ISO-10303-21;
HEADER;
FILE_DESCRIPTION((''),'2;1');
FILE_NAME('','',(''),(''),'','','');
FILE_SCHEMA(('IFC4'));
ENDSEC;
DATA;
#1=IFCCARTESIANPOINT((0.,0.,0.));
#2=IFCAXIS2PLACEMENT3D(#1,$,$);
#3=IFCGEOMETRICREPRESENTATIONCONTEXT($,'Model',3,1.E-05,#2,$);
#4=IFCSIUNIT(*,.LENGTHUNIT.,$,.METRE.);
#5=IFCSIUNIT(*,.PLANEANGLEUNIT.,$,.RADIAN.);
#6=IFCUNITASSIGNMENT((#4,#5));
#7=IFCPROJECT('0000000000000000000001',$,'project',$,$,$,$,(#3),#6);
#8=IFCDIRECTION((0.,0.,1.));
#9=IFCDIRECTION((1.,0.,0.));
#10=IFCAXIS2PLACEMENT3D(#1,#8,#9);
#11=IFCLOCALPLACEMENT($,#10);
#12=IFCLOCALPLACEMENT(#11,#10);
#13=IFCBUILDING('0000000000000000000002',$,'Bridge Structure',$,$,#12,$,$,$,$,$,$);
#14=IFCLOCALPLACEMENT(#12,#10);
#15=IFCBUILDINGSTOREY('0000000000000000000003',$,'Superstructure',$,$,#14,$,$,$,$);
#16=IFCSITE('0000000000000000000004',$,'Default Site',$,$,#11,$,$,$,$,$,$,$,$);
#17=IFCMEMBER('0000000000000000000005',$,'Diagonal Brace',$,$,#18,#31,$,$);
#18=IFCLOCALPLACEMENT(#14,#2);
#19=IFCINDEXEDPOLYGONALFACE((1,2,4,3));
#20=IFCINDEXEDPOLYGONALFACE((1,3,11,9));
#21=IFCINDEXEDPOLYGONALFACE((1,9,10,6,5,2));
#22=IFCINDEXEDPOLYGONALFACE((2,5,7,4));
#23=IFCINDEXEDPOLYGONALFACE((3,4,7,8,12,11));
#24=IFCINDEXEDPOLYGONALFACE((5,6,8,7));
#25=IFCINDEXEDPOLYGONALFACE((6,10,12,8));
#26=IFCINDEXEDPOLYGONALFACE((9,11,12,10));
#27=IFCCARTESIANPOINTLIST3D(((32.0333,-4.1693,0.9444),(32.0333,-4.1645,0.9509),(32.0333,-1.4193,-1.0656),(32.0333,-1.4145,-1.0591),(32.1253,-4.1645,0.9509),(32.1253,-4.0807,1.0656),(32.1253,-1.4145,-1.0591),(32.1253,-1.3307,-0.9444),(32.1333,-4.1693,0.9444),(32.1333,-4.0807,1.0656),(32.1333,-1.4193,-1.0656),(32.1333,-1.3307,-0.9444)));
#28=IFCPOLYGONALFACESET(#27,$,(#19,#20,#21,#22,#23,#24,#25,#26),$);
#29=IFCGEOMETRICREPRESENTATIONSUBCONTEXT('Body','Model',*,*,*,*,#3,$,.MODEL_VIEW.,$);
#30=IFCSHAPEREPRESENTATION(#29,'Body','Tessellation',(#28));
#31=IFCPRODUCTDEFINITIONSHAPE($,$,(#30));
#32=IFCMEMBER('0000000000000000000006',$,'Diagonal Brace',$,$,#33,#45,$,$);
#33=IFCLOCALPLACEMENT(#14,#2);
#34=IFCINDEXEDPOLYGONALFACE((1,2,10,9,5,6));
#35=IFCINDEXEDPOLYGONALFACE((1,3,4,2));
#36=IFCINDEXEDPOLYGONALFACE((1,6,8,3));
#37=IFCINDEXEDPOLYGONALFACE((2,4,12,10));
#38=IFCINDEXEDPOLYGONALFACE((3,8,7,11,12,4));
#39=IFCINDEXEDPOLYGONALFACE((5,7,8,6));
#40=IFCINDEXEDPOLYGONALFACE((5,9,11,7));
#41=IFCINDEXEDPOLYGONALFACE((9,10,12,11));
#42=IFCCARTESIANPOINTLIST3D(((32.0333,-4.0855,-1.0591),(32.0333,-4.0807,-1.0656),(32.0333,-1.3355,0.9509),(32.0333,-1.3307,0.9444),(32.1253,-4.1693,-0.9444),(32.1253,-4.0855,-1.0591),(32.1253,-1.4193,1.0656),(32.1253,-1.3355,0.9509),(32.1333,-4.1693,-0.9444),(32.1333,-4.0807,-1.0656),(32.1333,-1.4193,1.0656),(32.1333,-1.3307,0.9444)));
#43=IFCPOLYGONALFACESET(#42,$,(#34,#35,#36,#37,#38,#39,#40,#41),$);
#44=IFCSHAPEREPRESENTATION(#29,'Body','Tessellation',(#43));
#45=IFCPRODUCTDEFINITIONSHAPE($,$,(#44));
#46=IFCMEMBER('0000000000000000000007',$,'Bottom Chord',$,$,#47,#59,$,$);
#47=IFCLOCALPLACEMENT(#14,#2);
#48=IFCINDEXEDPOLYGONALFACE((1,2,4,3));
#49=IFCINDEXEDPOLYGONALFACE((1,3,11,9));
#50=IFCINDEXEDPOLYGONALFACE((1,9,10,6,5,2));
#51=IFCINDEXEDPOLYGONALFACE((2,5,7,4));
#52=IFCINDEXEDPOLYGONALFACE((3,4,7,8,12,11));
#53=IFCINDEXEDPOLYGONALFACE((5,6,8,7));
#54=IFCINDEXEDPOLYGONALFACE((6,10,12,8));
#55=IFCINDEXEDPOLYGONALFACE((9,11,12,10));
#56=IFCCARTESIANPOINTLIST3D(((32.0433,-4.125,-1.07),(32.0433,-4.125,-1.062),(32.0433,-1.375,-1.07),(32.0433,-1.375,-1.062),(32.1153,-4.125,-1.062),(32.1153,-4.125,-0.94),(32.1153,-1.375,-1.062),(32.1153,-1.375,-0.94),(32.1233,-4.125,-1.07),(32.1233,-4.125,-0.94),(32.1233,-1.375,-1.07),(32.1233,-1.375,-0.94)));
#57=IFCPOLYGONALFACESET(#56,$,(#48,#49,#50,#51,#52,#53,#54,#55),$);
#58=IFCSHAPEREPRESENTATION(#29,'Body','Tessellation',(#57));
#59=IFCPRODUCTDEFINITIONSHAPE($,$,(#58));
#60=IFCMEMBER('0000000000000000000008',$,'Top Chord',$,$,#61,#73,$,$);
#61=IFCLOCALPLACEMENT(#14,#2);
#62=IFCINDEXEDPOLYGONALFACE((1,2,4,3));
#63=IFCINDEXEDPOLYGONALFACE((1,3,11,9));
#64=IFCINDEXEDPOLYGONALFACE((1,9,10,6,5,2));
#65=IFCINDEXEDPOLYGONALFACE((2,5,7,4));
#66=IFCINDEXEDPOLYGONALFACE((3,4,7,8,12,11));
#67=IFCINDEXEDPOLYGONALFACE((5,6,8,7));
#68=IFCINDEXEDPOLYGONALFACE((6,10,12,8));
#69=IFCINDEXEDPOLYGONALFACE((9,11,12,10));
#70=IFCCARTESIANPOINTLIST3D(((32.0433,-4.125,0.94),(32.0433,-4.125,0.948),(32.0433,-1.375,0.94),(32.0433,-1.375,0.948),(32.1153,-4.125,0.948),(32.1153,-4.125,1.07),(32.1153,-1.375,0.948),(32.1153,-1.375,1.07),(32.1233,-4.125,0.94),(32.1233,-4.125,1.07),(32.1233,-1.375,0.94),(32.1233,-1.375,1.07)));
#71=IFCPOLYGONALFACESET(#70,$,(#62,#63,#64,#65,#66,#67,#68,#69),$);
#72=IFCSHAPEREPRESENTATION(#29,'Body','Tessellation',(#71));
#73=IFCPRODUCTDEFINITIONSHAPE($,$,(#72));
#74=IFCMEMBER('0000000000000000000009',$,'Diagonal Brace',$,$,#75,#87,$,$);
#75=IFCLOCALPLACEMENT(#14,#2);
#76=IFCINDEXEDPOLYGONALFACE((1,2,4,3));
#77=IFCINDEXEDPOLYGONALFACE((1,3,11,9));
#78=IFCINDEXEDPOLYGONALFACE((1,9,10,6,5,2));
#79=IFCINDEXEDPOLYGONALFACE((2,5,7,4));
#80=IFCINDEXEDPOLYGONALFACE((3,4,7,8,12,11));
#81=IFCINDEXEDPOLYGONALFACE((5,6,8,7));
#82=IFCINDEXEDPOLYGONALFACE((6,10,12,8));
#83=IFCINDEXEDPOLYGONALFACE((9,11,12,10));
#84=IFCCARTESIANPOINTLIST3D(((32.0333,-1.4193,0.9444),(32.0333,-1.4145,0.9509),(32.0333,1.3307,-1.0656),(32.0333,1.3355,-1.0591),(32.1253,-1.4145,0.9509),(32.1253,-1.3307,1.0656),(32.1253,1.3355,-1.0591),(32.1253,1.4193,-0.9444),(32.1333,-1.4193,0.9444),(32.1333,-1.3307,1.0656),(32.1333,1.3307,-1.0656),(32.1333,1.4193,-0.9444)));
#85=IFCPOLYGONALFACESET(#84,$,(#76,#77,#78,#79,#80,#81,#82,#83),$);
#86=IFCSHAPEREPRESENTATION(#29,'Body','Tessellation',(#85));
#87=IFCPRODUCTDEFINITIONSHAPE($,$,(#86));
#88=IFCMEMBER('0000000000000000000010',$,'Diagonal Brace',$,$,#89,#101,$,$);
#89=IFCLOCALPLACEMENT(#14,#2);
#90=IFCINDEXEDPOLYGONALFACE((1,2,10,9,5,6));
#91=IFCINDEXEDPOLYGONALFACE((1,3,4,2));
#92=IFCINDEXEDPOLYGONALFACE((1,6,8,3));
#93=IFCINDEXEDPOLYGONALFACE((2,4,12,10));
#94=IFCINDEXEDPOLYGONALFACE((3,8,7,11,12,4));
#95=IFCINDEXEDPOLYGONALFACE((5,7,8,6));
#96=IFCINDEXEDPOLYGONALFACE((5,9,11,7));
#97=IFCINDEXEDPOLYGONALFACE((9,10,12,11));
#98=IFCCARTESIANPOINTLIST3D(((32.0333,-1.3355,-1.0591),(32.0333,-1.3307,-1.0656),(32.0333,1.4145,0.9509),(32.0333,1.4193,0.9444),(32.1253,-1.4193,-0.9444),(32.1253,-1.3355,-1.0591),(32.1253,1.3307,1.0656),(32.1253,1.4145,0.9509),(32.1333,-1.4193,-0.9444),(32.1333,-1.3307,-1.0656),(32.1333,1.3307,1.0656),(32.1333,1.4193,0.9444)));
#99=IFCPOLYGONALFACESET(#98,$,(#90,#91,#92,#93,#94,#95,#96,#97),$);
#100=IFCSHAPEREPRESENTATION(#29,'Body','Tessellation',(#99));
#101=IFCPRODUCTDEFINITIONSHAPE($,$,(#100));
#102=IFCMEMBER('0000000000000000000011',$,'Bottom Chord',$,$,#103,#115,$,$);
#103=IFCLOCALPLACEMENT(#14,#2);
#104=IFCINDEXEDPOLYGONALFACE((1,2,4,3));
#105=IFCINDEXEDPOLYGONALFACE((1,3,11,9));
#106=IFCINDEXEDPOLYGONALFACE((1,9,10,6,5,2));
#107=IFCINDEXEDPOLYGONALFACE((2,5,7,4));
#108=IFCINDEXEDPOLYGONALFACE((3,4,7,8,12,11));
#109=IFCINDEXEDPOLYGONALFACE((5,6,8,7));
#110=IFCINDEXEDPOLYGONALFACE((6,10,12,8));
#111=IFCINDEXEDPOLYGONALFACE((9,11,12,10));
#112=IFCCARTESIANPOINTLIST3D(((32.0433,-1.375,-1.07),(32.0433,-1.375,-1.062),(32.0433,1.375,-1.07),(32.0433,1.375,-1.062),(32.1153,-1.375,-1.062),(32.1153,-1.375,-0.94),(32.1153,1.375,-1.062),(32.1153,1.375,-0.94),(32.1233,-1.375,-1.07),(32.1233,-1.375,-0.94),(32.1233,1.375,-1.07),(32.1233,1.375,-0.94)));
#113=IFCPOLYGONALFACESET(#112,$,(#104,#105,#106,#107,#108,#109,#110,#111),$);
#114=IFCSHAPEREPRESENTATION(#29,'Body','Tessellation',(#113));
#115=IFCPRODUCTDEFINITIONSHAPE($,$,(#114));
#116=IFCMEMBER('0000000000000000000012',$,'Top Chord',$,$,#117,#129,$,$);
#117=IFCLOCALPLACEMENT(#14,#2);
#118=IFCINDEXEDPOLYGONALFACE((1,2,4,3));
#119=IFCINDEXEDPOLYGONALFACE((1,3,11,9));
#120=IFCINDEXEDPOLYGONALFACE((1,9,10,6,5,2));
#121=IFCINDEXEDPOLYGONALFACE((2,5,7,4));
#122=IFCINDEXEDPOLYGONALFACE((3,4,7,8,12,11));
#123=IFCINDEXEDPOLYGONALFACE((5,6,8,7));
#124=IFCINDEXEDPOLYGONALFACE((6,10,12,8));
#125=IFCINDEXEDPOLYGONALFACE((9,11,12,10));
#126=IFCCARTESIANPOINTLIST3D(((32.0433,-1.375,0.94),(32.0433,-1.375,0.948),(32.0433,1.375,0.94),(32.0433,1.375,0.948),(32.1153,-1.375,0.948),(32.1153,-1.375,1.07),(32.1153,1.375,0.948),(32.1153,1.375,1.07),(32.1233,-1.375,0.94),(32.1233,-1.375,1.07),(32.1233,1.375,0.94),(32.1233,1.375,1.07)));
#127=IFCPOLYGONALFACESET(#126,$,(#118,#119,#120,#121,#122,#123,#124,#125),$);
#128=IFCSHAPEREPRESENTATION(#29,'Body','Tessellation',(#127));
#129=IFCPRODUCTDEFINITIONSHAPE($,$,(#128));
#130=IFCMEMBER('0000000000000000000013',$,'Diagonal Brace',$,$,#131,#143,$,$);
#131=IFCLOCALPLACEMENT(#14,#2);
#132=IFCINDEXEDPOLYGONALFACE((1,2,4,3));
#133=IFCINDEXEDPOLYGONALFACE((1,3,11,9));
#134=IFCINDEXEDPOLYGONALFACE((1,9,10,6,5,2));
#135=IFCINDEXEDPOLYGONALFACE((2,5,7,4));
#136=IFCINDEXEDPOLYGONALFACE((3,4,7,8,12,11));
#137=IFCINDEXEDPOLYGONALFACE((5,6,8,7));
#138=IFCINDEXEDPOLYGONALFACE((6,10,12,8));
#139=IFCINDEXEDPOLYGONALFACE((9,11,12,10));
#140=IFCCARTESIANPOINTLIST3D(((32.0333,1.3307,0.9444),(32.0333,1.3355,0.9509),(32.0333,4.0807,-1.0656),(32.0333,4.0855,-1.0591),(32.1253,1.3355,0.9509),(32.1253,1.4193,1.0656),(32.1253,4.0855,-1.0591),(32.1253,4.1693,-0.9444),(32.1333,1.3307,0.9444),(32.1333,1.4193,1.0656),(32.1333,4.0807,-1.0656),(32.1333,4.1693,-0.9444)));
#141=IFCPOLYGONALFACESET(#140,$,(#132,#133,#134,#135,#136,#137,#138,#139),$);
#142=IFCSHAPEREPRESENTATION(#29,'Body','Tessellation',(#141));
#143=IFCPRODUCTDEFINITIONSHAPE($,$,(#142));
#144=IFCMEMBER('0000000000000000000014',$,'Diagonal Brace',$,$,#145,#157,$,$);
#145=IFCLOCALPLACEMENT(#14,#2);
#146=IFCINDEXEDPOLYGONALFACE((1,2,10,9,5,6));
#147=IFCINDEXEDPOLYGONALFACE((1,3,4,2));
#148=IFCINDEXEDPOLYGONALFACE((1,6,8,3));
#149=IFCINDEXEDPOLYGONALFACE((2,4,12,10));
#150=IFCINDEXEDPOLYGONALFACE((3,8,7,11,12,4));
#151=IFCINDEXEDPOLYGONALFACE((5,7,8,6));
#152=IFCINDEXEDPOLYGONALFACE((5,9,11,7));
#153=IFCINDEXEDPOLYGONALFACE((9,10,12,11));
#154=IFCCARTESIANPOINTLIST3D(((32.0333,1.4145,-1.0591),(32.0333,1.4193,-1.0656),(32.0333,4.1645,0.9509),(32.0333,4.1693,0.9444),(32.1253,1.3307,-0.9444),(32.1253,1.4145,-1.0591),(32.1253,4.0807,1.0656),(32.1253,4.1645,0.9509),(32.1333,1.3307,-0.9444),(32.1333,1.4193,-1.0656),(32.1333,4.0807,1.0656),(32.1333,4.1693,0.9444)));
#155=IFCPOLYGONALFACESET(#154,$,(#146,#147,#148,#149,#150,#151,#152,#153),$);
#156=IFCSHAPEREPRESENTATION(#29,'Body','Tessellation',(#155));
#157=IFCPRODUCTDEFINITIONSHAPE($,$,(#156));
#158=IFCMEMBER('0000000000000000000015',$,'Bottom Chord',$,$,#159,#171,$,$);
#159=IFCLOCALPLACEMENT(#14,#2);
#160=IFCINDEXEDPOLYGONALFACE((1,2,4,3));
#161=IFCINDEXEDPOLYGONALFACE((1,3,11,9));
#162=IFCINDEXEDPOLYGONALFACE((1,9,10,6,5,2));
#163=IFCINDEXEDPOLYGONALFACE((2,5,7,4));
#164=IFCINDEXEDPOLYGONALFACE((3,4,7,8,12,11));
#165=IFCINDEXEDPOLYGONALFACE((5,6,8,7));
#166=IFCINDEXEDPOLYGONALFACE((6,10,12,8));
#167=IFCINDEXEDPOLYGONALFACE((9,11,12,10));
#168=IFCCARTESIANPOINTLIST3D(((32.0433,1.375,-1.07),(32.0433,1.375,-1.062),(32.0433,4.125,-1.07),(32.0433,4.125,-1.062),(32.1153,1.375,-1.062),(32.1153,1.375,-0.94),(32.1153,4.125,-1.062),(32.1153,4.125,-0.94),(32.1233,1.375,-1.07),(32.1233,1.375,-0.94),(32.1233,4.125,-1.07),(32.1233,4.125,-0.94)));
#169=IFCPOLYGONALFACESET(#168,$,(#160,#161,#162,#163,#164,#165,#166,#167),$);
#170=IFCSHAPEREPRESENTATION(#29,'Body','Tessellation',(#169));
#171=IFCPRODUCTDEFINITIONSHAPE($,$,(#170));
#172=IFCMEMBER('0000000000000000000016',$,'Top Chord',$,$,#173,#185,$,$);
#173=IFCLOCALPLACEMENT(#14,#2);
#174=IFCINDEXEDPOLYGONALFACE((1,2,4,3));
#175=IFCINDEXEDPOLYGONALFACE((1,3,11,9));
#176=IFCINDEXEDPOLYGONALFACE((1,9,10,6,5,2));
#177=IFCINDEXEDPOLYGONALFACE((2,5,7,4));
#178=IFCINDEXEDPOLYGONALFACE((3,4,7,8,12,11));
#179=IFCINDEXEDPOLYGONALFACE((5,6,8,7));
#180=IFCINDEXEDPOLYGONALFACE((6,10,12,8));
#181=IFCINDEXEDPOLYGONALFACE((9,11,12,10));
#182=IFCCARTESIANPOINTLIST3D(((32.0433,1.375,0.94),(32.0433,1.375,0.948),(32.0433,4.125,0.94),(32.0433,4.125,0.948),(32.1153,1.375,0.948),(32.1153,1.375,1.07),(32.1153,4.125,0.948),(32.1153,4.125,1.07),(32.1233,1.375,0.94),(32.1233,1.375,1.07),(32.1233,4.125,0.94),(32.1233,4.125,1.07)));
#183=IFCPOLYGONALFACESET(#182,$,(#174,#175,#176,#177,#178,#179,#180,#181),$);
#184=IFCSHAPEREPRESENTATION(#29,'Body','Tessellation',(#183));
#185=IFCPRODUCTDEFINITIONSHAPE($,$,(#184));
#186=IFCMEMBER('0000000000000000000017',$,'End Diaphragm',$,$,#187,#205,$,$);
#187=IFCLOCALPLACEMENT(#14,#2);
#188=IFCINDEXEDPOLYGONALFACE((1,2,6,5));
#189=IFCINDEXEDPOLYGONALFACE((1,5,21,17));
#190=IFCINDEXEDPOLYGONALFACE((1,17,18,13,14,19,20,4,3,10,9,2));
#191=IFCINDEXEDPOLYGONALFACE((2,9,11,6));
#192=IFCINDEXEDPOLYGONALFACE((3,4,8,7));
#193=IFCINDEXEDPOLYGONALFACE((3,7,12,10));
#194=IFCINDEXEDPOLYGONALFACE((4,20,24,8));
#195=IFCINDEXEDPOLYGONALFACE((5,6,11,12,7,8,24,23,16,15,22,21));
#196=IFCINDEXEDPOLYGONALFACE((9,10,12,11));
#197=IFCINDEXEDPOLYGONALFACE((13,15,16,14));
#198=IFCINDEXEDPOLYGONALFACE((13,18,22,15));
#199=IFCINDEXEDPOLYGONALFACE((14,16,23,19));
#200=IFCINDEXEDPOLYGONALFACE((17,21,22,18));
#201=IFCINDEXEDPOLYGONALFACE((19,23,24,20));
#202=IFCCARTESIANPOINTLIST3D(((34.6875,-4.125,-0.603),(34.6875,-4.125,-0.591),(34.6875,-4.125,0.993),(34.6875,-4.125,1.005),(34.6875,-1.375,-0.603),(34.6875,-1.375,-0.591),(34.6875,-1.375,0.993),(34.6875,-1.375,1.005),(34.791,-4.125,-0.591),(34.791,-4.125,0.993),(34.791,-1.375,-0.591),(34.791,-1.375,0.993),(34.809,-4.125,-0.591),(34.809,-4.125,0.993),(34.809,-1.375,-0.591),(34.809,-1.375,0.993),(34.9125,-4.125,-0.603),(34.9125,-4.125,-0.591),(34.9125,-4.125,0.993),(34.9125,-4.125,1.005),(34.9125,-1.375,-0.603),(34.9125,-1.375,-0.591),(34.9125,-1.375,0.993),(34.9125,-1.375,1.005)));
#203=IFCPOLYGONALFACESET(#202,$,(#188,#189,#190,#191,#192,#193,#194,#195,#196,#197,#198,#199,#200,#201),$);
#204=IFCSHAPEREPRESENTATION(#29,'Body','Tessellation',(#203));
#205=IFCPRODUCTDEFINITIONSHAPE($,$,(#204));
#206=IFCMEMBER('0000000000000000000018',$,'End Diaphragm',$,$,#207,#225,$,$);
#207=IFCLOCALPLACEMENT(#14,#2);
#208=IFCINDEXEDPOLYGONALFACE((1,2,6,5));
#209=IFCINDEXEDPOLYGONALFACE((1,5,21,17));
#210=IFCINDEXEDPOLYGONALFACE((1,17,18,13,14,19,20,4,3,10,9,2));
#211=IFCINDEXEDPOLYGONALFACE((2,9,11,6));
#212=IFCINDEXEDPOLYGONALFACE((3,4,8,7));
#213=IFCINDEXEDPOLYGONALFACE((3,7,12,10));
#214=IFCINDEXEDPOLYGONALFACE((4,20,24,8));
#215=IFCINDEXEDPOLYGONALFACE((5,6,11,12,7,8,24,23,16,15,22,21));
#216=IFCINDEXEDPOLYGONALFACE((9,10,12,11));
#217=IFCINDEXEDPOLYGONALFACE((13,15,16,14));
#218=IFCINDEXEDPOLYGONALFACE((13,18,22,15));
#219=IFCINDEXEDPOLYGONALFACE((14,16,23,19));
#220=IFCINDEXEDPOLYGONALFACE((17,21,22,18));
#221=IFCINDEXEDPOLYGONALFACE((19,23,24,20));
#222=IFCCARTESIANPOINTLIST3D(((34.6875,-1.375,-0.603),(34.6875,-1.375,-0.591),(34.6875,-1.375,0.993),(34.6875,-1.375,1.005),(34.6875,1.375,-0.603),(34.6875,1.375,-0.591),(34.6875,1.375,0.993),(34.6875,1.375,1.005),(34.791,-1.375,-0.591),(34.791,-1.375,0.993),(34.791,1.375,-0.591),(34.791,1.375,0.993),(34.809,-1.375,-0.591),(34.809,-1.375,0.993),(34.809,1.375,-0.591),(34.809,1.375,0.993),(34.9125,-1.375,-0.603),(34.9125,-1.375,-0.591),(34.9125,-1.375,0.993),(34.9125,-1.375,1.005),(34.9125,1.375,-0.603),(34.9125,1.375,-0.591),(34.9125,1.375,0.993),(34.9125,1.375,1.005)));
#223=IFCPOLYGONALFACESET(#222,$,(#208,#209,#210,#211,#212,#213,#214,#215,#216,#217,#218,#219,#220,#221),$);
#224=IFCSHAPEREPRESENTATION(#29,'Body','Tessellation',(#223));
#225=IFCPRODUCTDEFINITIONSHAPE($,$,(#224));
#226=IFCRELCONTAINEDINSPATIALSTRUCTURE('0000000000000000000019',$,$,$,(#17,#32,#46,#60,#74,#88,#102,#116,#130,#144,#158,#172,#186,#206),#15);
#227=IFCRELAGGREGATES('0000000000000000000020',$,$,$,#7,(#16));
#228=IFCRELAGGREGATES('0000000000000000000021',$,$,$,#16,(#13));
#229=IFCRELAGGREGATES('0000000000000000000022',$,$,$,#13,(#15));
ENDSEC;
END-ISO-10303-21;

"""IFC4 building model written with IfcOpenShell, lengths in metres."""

from ifc_helpers import new_model, si_unit, frame, origin, origin_with_axes, origin_2d_with_axis, place, context, subcontext, project, spatial, i_section, l_section, extrude, element, save


model = new_model("IFC4")

# Units and contexts
model_context = context("Model", 3, precision=1e-05, world=origin())
body_context = subcontext(model_context, "Body", "Model", "MODEL_VIEW")
ifc_project = project(units=[si_unit("LENGTHUNIT", "METRE"), si_unit("PLANEANGLEUNIT", "RADIAN")], contexts=[model_context])

# Site, building, storey
site_placement = place(None, origin_with_axes())
site = spatial("IfcSite", under=ifc_project, at=site_placement, Name="Default Site")
building_placement = place(site_placement, origin_with_axes())
building = spatial("IfcBuilding", under=site, at=building_placement, Name="Bridge Structure")
storey_placement = place(building_placement, origin_with_axes())
storey = spatial("IfcBuildingStorey", under=building, at=storey_placement, Name="Superstructure")

# Members
for number, where, z_axis, x_axis, name in (
    (1, (32.0833, -4.125, 1.005), (0.0, 0.807337, -0.59009), (-1.0, 0.0, 0.0), "Diagonal Brace"),
    (2, (32.0833, -4.125, -1.005), (0.0, 0.807337, 0.59009), (-1.0, 0.0, 0.0), "Diagonal Brace"),
):
    element("IfcMember", number, at=place(storey_placement, frame(where, z_axis=z_axis, x_axis=x_axis)), inside=storey, Name=name, context=body_context, shape_type="SweptSolid", body=[
        extrude(l_section(Depth=0.15, Width=0.1, Thickness=0.008, at=origin_2d_with_axis()), origin_with_axes(), (0.0, 0.0, 1.0), 3.4063),
    ])
for number, where, z_axis, x_axis, name in (
    (3, (32.0833, -4.125, -1.005), (0.0, 1.0, 0.0), (-1.0, 0.0, 0.0), "Bottom Chord"),
    (4, (32.0833, -4.125, 1.005), (0.0, 1.0, 0.0), (-1.0, 0.0, 0.0), "Top Chord"),
):
    element("IfcMember", number, at=place(storey_placement, frame(where, z_axis=z_axis, x_axis=x_axis)), inside=storey, Name=name, context=body_context, shape_type="SweptSolid", body=[
        extrude(l_section(Depth=0.13, Width=0.08, Thickness=0.008, at=origin_2d_with_axis()), origin_with_axes(), (0.0, 0.0, 1.0), 2.75),
    ])
for number, where, z_axis, x_axis, name in (
    (5, (32.0833, -1.375, 1.005), (0.0, 0.807337, -0.59009), (-1.0, 0.0, 0.0), "Diagonal Brace"),
    (6, (32.0833, -1.375, -1.005), (0.0, 0.807337, 0.59009), (-1.0, 0.0, 0.0), "Diagonal Brace"),
):
    element("IfcMember", number, at=place(storey_placement, frame(where, z_axis=z_axis, x_axis=x_axis)), inside=storey, Name=name, context=body_context, shape_type="SweptSolid", body=[
        extrude(l_section(Depth=0.15, Width=0.1, Thickness=0.008, at=origin_2d_with_axis()), origin_with_axes(), (0.0, 0.0, 1.0), 3.4063),
    ])
for number, where, z_axis, x_axis, name in (
    (7, (32.0833, -1.375, -1.005), (0.0, 1.0, 0.0), (-1.0, 0.0, 0.0), "Bottom Chord"),
    (8, (32.0833, -1.375, 1.005), (0.0, 1.0, 0.0), (-1.0, 0.0, 0.0), "Top Chord"),
):
    element("IfcMember", number, at=place(storey_placement, frame(where, z_axis=z_axis, x_axis=x_axis)), inside=storey, Name=name, context=body_context, shape_type="SweptSolid", body=[
        extrude(l_section(Depth=0.13, Width=0.08, Thickness=0.008, at=origin_2d_with_axis()), origin_with_axes(), (0.0, 0.0, 1.0), 2.75),
    ])
for number, where, z_axis, x_axis, name in (
    (9, (32.0833, 1.375, 1.005), (0.0, 0.807337, -0.59009), (-1.0, 0.0, 0.0), "Diagonal Brace"),
    (10, (32.0833, 1.375, -1.005), (0.0, 0.807337, 0.59009), (-1.0, 0.0, 0.0), "Diagonal Brace"),
):
    element("IfcMember", number, at=place(storey_placement, frame(where, z_axis=z_axis, x_axis=x_axis)), inside=storey, Name=name, context=body_context, shape_type="SweptSolid", body=[
        extrude(l_section(Depth=0.15, Width=0.1, Thickness=0.008, at=origin_2d_with_axis()), origin_with_axes(), (0.0, 0.0, 1.0), 3.4063),
    ])
for number, where, z_axis, x_axis, name in (
    (11, (32.0833, 1.375, -1.005), (0.0, 1.0, 0.0), (-1.0, 0.0, 0.0), "Bottom Chord"),
    (12, (32.0833, 1.375, 1.005), (0.0, 1.0, 0.0), (-1.0, 0.0, 0.0), "Top Chord"),
):
    element("IfcMember", number, at=place(storey_placement, frame(where, z_axis=z_axis, x_axis=x_axis)), inside=storey, Name=name, context=body_context, shape_type="SweptSolid", body=[
        extrude(l_section(Depth=0.13, Width=0.08, Thickness=0.008, at=origin_2d_with_axis()), origin_with_axes(), (0.0, 0.0, 1.0), 2.75),
    ])
for number, where, z_axis, x_axis, name in (
    (13, (34.8, -4.125, 0.201), (0.0, 1.0, 0.0), (-1.0, 0.0, 0.0), "End Diaphragm"),
    (14, (34.8, -1.375, 0.201), (0.0, 1.0, 0.0), (-1.0, 0.0, 0.0), "End Diaphragm"),
):
    element("IfcMember", number, at=place(storey_placement, frame(where, z_axis=z_axis, x_axis=x_axis)), inside=storey, Name=name, context=body_context, shape_type="SweptSolid", body=[
        extrude(i_section(OverallWidth=0.225, OverallDepth=1.608, WebThickness=0.018, FlangeThickness=0.012, at=origin_2d_with_axis()), origin_with_axes(), (0.0, 0.0, 1.0), 2.75),
    ])

save(model, "model.ifc")
